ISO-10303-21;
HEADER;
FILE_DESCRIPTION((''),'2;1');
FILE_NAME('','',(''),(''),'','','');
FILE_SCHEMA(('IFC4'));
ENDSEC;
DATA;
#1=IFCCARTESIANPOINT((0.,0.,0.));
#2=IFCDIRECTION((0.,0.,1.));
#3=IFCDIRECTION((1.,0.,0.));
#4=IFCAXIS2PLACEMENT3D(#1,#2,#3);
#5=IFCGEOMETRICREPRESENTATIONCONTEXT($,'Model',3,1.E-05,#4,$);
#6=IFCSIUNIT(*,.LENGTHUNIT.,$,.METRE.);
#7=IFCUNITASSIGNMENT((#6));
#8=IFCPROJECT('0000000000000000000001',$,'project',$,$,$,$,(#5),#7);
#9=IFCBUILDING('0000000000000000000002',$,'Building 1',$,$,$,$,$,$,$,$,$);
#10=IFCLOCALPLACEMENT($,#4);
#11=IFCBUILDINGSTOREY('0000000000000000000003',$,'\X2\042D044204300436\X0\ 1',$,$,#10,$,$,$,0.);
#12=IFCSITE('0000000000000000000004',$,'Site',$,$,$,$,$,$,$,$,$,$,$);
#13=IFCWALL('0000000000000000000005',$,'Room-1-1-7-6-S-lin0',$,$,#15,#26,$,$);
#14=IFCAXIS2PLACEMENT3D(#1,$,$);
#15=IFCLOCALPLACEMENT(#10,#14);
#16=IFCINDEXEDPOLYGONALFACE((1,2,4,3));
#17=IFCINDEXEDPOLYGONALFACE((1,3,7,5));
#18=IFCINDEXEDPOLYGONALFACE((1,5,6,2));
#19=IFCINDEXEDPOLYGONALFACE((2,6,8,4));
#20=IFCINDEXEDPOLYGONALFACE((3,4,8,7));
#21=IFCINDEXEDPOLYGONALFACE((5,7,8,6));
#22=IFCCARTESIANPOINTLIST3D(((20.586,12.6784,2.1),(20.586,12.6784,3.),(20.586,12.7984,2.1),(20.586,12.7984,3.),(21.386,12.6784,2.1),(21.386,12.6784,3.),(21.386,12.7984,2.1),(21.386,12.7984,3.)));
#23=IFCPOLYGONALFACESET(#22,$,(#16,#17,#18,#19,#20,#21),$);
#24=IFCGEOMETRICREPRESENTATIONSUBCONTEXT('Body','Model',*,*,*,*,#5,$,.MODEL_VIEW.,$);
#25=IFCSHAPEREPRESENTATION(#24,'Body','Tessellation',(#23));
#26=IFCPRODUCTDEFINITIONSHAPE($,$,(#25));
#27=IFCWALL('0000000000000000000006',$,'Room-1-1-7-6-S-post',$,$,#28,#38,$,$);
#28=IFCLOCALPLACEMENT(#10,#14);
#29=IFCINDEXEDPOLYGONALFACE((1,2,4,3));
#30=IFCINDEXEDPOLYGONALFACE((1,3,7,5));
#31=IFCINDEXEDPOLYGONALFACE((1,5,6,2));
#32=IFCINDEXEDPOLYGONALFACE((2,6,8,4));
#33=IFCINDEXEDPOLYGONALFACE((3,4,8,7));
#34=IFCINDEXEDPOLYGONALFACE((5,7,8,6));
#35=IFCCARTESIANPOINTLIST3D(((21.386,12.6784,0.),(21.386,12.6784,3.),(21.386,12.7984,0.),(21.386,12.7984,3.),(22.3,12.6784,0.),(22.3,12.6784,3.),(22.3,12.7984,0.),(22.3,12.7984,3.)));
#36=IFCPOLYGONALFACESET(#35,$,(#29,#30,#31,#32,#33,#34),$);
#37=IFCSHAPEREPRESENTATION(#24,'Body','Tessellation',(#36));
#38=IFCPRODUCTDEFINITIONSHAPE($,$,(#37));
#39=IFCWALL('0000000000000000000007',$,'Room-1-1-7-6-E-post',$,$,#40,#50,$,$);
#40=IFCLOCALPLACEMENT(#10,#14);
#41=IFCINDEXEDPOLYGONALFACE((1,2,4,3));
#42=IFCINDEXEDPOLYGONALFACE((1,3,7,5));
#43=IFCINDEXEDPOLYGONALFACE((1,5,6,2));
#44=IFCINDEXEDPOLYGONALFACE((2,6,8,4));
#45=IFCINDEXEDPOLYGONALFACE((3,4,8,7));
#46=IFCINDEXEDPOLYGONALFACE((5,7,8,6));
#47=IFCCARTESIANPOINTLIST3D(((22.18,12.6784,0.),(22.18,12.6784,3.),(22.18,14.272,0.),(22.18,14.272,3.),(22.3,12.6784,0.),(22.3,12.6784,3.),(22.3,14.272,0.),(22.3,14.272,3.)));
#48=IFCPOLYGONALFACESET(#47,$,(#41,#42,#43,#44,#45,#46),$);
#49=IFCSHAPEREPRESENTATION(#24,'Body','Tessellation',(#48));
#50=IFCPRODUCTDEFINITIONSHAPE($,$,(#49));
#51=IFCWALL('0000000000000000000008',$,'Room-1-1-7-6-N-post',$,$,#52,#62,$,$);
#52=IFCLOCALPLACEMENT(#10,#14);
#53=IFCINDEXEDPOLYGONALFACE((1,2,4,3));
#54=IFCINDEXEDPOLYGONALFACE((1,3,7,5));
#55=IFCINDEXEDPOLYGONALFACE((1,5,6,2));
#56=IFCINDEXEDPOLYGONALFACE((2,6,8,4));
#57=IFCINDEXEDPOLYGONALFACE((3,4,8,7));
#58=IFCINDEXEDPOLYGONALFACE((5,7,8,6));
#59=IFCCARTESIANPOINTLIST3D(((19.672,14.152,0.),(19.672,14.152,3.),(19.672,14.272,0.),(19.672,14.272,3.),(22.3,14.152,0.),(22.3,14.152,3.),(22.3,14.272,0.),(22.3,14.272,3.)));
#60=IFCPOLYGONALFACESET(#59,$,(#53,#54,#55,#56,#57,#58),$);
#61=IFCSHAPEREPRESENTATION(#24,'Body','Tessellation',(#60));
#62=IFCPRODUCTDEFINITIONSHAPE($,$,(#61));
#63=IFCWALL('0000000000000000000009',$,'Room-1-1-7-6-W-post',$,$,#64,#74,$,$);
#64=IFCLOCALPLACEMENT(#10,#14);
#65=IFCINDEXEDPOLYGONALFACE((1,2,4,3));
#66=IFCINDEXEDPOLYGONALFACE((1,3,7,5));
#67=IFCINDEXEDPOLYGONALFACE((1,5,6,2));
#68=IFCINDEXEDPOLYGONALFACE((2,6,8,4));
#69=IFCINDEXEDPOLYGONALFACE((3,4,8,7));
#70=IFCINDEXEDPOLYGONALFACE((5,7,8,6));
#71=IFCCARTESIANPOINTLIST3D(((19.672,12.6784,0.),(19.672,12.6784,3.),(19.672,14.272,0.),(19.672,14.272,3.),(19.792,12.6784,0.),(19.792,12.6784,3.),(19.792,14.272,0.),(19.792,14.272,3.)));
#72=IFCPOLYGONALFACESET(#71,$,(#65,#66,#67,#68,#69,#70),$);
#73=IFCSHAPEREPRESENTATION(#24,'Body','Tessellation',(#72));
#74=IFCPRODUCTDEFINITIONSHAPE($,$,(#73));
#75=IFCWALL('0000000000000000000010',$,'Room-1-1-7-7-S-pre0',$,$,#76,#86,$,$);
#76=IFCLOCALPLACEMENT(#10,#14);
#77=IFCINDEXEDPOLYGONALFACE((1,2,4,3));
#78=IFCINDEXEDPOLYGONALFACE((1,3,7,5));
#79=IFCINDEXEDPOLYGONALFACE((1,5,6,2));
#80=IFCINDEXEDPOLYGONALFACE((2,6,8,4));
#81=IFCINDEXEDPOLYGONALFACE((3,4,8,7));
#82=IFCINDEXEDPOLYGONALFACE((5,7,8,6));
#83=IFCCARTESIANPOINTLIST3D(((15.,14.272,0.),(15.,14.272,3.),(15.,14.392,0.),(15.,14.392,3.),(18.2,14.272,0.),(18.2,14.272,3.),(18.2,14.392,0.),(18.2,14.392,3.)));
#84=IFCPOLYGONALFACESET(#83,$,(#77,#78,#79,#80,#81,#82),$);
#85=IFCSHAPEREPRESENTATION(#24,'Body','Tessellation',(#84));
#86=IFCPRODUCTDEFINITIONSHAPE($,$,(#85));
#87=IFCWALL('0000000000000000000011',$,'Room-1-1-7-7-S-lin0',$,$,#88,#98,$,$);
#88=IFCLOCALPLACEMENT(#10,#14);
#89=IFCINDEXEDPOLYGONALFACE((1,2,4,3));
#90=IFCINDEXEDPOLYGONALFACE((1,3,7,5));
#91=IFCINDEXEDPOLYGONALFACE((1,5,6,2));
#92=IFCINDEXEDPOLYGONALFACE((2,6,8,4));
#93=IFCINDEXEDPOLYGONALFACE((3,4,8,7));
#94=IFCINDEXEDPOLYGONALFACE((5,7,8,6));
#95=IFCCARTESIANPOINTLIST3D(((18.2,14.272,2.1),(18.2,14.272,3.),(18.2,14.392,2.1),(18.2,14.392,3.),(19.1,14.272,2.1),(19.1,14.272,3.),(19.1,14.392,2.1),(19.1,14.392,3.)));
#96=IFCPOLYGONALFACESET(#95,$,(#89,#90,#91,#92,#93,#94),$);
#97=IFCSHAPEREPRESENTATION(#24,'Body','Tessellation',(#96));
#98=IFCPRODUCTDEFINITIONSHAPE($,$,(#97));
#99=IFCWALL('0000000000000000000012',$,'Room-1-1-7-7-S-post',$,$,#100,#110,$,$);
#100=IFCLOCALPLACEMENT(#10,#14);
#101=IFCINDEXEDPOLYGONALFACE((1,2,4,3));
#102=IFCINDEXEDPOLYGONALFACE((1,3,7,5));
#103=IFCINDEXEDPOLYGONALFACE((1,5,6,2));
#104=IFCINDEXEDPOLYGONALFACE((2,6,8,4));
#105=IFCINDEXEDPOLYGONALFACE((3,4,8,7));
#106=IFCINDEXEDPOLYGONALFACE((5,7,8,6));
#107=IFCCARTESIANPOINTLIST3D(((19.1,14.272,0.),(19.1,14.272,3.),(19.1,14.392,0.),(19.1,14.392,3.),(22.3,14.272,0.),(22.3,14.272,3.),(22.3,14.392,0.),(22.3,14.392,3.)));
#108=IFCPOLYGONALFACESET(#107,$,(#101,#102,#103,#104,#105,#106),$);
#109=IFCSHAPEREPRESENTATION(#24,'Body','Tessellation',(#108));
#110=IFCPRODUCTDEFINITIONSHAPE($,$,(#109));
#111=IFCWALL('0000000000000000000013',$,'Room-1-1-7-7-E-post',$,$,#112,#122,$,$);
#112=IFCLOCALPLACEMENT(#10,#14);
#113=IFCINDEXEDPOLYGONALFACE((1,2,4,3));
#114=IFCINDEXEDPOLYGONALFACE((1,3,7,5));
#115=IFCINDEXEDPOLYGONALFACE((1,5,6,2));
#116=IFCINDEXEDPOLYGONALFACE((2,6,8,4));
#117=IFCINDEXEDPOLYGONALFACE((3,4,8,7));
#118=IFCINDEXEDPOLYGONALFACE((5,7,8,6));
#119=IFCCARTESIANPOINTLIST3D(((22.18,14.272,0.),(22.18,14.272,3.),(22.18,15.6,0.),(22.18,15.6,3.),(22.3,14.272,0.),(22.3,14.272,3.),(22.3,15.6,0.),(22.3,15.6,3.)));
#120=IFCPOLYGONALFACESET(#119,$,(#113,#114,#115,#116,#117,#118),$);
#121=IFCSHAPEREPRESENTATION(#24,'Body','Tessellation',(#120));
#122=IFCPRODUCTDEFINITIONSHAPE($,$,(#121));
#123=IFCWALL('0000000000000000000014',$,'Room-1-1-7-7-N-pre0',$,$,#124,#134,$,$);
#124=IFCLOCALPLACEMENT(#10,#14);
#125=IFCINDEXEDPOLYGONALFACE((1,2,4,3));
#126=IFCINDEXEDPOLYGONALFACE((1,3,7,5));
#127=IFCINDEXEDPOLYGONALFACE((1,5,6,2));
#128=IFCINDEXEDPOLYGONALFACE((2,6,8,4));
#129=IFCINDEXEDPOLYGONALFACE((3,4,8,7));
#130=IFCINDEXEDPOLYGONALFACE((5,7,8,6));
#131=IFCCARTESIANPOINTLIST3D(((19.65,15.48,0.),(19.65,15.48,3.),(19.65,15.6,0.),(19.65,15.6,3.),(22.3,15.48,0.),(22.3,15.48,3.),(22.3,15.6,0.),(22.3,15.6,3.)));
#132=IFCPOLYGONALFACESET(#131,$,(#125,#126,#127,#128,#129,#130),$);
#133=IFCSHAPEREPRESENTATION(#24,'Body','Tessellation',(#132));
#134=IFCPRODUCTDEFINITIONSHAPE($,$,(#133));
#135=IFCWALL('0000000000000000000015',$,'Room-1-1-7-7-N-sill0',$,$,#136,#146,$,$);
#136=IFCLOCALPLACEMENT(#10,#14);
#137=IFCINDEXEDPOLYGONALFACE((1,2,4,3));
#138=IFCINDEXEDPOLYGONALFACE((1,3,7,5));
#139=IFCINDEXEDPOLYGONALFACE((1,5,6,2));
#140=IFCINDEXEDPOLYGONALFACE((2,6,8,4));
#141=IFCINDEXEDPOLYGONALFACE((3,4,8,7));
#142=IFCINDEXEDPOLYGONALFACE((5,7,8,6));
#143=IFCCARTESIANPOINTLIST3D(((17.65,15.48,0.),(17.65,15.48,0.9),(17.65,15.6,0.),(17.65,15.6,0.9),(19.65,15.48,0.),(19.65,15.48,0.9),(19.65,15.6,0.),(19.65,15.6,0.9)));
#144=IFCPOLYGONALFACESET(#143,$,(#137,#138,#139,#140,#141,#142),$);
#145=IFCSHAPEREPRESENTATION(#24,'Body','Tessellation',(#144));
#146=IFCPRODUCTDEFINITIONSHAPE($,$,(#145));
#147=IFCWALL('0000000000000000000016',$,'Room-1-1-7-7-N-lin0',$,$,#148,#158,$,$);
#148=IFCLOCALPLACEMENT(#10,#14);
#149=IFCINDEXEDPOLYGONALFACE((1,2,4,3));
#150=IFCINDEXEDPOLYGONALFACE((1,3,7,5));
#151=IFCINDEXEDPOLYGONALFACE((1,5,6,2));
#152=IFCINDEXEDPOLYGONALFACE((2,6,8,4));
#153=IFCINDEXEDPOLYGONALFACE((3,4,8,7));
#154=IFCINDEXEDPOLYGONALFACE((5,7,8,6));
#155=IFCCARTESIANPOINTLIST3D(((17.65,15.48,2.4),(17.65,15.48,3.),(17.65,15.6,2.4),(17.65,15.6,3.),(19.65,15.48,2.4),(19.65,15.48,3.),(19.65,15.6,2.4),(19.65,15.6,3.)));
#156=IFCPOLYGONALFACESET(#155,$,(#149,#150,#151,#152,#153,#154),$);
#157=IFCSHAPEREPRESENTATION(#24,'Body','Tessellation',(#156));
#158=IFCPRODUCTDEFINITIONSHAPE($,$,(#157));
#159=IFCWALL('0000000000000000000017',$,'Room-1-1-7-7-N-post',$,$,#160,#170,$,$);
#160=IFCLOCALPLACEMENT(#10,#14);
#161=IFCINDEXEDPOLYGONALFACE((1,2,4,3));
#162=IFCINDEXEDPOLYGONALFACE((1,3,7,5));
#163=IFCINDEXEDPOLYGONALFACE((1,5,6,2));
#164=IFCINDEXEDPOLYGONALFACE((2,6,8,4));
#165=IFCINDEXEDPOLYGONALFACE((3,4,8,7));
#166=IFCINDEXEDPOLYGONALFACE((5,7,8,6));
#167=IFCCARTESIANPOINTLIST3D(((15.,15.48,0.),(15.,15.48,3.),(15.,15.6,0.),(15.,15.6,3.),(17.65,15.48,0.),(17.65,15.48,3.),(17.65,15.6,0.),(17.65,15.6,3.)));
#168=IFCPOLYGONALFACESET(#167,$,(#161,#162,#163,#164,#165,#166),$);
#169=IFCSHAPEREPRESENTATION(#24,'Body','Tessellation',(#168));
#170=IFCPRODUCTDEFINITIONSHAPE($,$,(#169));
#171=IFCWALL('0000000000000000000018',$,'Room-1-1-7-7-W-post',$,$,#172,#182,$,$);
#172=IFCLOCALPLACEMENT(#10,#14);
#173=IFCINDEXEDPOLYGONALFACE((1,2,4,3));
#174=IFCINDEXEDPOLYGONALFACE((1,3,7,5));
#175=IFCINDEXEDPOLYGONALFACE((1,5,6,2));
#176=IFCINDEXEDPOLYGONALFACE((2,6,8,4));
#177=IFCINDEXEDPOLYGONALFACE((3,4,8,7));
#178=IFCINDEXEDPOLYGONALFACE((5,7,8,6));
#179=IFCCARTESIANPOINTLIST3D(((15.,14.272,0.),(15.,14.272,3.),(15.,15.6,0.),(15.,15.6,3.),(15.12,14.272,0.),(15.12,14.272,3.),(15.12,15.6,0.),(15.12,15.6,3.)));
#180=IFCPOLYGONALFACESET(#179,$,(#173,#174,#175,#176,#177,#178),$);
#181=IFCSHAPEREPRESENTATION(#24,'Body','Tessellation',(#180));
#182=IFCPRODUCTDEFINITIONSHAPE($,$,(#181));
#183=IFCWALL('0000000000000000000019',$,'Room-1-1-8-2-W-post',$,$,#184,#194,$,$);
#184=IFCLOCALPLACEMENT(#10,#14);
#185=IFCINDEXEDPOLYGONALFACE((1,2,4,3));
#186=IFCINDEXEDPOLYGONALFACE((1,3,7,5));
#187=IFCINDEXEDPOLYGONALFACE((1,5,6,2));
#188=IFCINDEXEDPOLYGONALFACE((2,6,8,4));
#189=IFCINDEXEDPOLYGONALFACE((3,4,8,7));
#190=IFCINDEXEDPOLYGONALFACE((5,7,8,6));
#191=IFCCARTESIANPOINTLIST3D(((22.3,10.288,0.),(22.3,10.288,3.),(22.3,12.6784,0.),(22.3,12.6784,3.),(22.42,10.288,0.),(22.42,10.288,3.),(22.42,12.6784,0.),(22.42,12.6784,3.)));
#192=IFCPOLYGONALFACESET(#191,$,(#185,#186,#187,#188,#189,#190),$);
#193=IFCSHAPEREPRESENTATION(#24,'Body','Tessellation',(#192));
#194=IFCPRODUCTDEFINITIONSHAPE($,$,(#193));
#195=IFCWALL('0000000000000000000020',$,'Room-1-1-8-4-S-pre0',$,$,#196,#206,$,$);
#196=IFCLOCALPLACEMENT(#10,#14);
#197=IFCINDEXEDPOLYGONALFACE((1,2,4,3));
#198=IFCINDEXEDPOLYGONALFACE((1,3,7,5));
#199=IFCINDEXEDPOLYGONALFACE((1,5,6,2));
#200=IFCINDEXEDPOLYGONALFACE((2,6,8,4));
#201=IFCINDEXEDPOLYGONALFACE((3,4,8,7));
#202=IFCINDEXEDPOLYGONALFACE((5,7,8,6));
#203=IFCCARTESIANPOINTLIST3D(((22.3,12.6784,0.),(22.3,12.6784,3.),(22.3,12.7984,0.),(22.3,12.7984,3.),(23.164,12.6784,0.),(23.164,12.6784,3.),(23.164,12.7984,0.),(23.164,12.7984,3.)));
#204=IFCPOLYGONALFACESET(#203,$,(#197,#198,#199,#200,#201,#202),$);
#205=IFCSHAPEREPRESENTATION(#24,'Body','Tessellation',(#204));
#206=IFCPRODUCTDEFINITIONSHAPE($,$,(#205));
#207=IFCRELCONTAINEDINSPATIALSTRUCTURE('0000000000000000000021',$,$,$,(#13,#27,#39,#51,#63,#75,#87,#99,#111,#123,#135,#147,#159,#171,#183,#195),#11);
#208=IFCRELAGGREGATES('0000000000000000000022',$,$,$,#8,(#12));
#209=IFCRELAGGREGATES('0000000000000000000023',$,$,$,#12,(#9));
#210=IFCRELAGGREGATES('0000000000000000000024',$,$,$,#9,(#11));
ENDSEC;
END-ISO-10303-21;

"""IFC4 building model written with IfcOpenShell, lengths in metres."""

from ifc_helpers import new_model, si_unit, frame, origin_with_axes, place, context, subcontext, project, spatial, indexed_curve, outline, extrude, element, save


model = new_model("IFC4")

# Units and contexts
model_context = context("Model", 3, precision=1e-05, world=origin_with_axes())
body_context = subcontext(model_context, "Body", "Model", "MODEL_VIEW")
ifc_project = project(units=[si_unit("LENGTHUNIT", "METRE")], contexts=[model_context])

# Site, building, storey
site = spatial("IfcSite", under=ifc_project, Name="Site")
building = spatial("IfcBuilding", under=site, Name="Building 1")
storey_placement = place(None, origin_with_axes())
storey = spatial("IfcBuildingStorey", under=building, at=storey_placement, Name="Этаж 1", Elevation=0.0)

# Walls
wall_1_placement = place(storey_placement, frame((20.586, 12.6784, 2.1), z_axis=(0.0, 0.0, 1.0), x_axis=(1.0, 0.0, 0.0)))
element("IfcWall", 1, at=wall_1_placement, inside=storey, Name="Room-1-1-7-6-S-lin0", context=body_context, shape_type="SweptSolid", body=[
    extrude(outline(indexed_curve([(0.0, 0.0), (0.0, 0.12), (0.8, 0.12), (0.8, 0.0), (0.0, 0.0)], self_intersect=False)), origin_with_axes(), (0.0, 0.0, 1.0), 0.9),
])
wall_2_placement = place(storey_placement, frame((21.386, 12.6784, 0.0), z_axis=(0.0, 0.0, 1.0), x_axis=(1.0, 0.0, 0.0)))
element("IfcWall", 2, at=wall_2_placement, inside=storey, Name="Room-1-1-7-6-S-post", context=body_context, shape_type="SweptSolid", body=[
    extrude(outline(indexed_curve([(0.0, 0.0), (0.0, 0.12), (0.914, 0.12), (0.914, 0.0), (0.0, 0.0)], self_intersect=False)), origin_with_axes(), (0.0, 0.0, 1.0), 3.0),
])
wall_3_placement = place(storey_placement, frame((22.3, 12.6784, 0.0), z_axis=(0.0, 0.0, 1.0), x_axis=(0.0, 1.0, 0.0)))
element("IfcWall", 3, at=wall_3_placement, inside=storey, Name="Room-1-1-7-6-E-post", context=body_context, shape_type="SweptSolid", body=[
    extrude(outline(indexed_curve([(0.0, 0.0), (0.0, 0.12), (1.5936, 0.12), (1.5936, 0.0), (0.0, 0.0)], self_intersect=False)), origin_with_axes(), (0.0, 0.0, 1.0), 3.0),
])
wall_4_placement = place(storey_placement, frame((22.3, 14.272, 0.0), z_axis=(0.0, 0.0, 1.0), x_axis=(-1.0, 0.0, 0.0)))
element("IfcWall", 4, at=wall_4_placement, inside=storey, Name="Room-1-1-7-6-N-post", context=body_context, shape_type="SweptSolid", body=[
    extrude(outline(indexed_curve([(0.0, 0.0), (0.0, 0.12), (2.628, 0.12), (2.628, 0.0), (0.0, 0.0)], self_intersect=False)), origin_with_axes(), (0.0, 0.0, 1.0), 3.0),
])
wall_5_placement = place(storey_placement, frame((19.672, 14.272, 0.0), z_axis=(0.0, 0.0, 1.0), x_axis=(0.0, -1.0, 0.0)))
element("IfcWall", 5, at=wall_5_placement, inside=storey, Name="Room-1-1-7-6-W-post", context=body_context, shape_type="SweptSolid", body=[
    extrude(outline(indexed_curve([(0.0, 0.0), (0.0, 0.12), (1.5936, 0.12), (1.5936, 0.0), (0.0, 0.0)], self_intersect=False)), origin_with_axes(), (0.0, 0.0, 1.0), 3.0),
])
wall_6_placement = place(storey_placement, frame((15.0, 14.272, 0.0), z_axis=(0.0, 0.0, 1.0), x_axis=(1.0, 0.0, 0.0)))
element("IfcWall", 6, at=wall_6_placement, inside=storey, Name="Room-1-1-7-7-S-pre0", context=body_context, shape_type="SweptSolid", body=[
    extrude(outline(indexed_curve([(0.0, 0.0), (0.0, 0.12), (3.2, 0.12), (3.2, 0.0), (0.0, 0.0)], self_intersect=False)), origin_with_axes(), (0.0, 0.0, 1.0), 3.0),
])
wall_7_placement = place(storey_placement, frame((18.2, 14.272, 2.1), z_axis=(0.0, 0.0, 1.0), x_axis=(1.0, 0.0, 0.0)))
element("IfcWall", 7, at=wall_7_placement, inside=storey, Name="Room-1-1-7-7-S-lin0", context=body_context, shape_type="SweptSolid", body=[
    extrude(outline(indexed_curve([(0.0, 0.0), (0.0, 0.12), (0.9, 0.12), (0.9, 0.0), (0.0, 0.0)], self_intersect=False)), origin_with_axes(), (0.0, 0.0, 1.0), 0.9),
])
wall_8_placement = place(storey_placement, frame((19.1, 14.272, 0.0), z_axis=(0.0, 0.0, 1.0), x_axis=(1.0, 0.0, 0.0)))
element("IfcWall", 8, at=wall_8_placement, inside=storey, Name="Room-1-1-7-7-S-post", context=body_context, shape_type="SweptSolid", body=[
    extrude(outline(indexed_curve([(0.0, 0.0), (0.0, 0.12), (3.2, 0.12), (3.2, 0.0), (0.0, 0.0)], self_intersect=False)), origin_with_axes(), (0.0, 0.0, 1.0), 3.0),
])
wall_9_placement = place(storey_placement, frame((22.3, 14.272, 0.0), z_axis=(0.0, 0.0, 1.0), x_axis=(0.0, 1.0, 0.0)))
element("IfcWall", 9, at=wall_9_placement, inside=storey, Name="Room-1-1-7-7-E-post", context=body_context, shape_type="SweptSolid", body=[
    extrude(outline(indexed_curve([(0.0, 0.0), (0.0, 0.12), (1.328, 0.12), (1.328, 0.0), (0.0, 0.0)], self_intersect=False)), origin_with_axes(), (0.0, 0.0, 1.0), 3.0),
])
wall_10_placement = place(storey_placement, frame((22.3, 15.6, 0.0), z_axis=(0.0, 0.0, 1.0), x_axis=(-1.0, 0.0, 0.0)))
element("IfcWall", 10, at=wall_10_placement, inside=storey, Name="Room-1-1-7-7-N-pre0", context=body_context, shape_type="SweptSolid", body=[
    extrude(outline(indexed_curve([(0.0, 0.0), (0.0, 0.12), (2.65, 0.12), (2.65, 0.0), (0.0, 0.0)], self_intersect=False)), origin_with_axes(), (0.0, 0.0, 1.0), 3.0),
])
wall_11_placement = place(storey_placement, frame((19.65, 15.6, 0.0), z_axis=(0.0, 0.0, 1.0), x_axis=(-1.0, 0.0, 0.0)))
element("IfcWall", 11, at=wall_11_placement, inside=storey, Name="Room-1-1-7-7-N-sill0", context=body_context, shape_type="SweptSolid", body=[
    extrude(outline(indexed_curve([(0.0, 0.0), (0.0, 0.12), (2.0, 0.12), (2.0, 0.0), (0.0, 0.0)], self_intersect=False)), origin_with_axes(), (0.0, 0.0, 1.0), 0.9),
])
wall_12_placement = place(storey_placement, frame((19.65, 15.6, 2.4), z_axis=(0.0, 0.0, 1.0), x_axis=(-1.0, 0.0, 0.0)))
element("IfcWall", 12, at=wall_12_placement, inside=storey, Name="Room-1-1-7-7-N-lin0", context=body_context, shape_type="SweptSolid", body=[
    extrude(outline(indexed_curve([(0.0, 0.0), (0.0, 0.12), (2.0, 0.12), (2.0, 0.0), (0.0, 0.0)], self_intersect=False)), origin_with_axes(), (0.0, 0.0, 1.0), 0.6),
])
wall_13_placement = place(storey_placement, frame((17.65, 15.6, 0.0), z_axis=(0.0, 0.0, 1.0), x_axis=(-1.0, 0.0, 0.0)))
element("IfcWall", 13, at=wall_13_placement, inside=storey, Name="Room-1-1-7-7-N-post", context=body_context, shape_type="SweptSolid", body=[
    extrude(outline(indexed_curve([(0.0, 0.0), (0.0, 0.12), (2.65, 0.12), (2.65, 0.0), (0.0, 0.0)], self_intersect=False)), origin_with_axes(), (0.0, 0.0, 1.0), 3.0),
])
wall_14_placement = place(storey_placement, frame((15.0, 15.6, 0.0), z_axis=(0.0, 0.0, 1.0), x_axis=(0.0, -1.0, 0.0)))
element("IfcWall", 14, at=wall_14_placement, inside=storey, Name="Room-1-1-7-7-W-post", context=body_context, shape_type="SweptSolid", body=[
    extrude(outline(indexed_curve([(0.0, 0.0), (0.0, 0.12), (1.328, 0.12), (1.328, 0.0), (0.0, 0.0)], self_intersect=False)), origin_with_axes(), (0.0, 0.0, 1.0), 3.0),
])
wall_15_placement = place(storey_placement, frame((22.3, 12.6784, 0.0), z_axis=(0.0, 0.0, 1.0), x_axis=(0.0, -1.0, 0.0)))
element("IfcWall", 15, at=wall_15_placement, inside=storey, Name="Room-1-1-8-2-W-post", context=body_context, shape_type="SweptSolid", body=[
    extrude(outline(indexed_curve([(0.0, 0.0), (0.0, 0.12), (2.3904, 0.12), (2.3904, 0.0), (0.0, 0.0)], self_intersect=False)), origin_with_axes(), (0.0, 0.0, 1.0), 3.0),
])
wall_16_placement = place(storey_placement, frame((22.3, 12.6784, 0.0), z_axis=(0.0, 0.0, 1.0), x_axis=(1.0, 0.0, 0.0)))
element("IfcWall", 16, at=wall_16_placement, inside=storey, Name="Room-1-1-8-4-S-pre0", context=body_context, shape_type="SweptSolid", body=[
    extrude(outline(indexed_curve([(0.0, 0.0), (0.0, 0.12), (0.864, 0.12), (0.864, 0.0), (0.0, 0.0)], self_intersect=False)), origin_with_axes(), (0.0, 0.0, 1.0), 3.0),
])

save(model, "model.ifc")
